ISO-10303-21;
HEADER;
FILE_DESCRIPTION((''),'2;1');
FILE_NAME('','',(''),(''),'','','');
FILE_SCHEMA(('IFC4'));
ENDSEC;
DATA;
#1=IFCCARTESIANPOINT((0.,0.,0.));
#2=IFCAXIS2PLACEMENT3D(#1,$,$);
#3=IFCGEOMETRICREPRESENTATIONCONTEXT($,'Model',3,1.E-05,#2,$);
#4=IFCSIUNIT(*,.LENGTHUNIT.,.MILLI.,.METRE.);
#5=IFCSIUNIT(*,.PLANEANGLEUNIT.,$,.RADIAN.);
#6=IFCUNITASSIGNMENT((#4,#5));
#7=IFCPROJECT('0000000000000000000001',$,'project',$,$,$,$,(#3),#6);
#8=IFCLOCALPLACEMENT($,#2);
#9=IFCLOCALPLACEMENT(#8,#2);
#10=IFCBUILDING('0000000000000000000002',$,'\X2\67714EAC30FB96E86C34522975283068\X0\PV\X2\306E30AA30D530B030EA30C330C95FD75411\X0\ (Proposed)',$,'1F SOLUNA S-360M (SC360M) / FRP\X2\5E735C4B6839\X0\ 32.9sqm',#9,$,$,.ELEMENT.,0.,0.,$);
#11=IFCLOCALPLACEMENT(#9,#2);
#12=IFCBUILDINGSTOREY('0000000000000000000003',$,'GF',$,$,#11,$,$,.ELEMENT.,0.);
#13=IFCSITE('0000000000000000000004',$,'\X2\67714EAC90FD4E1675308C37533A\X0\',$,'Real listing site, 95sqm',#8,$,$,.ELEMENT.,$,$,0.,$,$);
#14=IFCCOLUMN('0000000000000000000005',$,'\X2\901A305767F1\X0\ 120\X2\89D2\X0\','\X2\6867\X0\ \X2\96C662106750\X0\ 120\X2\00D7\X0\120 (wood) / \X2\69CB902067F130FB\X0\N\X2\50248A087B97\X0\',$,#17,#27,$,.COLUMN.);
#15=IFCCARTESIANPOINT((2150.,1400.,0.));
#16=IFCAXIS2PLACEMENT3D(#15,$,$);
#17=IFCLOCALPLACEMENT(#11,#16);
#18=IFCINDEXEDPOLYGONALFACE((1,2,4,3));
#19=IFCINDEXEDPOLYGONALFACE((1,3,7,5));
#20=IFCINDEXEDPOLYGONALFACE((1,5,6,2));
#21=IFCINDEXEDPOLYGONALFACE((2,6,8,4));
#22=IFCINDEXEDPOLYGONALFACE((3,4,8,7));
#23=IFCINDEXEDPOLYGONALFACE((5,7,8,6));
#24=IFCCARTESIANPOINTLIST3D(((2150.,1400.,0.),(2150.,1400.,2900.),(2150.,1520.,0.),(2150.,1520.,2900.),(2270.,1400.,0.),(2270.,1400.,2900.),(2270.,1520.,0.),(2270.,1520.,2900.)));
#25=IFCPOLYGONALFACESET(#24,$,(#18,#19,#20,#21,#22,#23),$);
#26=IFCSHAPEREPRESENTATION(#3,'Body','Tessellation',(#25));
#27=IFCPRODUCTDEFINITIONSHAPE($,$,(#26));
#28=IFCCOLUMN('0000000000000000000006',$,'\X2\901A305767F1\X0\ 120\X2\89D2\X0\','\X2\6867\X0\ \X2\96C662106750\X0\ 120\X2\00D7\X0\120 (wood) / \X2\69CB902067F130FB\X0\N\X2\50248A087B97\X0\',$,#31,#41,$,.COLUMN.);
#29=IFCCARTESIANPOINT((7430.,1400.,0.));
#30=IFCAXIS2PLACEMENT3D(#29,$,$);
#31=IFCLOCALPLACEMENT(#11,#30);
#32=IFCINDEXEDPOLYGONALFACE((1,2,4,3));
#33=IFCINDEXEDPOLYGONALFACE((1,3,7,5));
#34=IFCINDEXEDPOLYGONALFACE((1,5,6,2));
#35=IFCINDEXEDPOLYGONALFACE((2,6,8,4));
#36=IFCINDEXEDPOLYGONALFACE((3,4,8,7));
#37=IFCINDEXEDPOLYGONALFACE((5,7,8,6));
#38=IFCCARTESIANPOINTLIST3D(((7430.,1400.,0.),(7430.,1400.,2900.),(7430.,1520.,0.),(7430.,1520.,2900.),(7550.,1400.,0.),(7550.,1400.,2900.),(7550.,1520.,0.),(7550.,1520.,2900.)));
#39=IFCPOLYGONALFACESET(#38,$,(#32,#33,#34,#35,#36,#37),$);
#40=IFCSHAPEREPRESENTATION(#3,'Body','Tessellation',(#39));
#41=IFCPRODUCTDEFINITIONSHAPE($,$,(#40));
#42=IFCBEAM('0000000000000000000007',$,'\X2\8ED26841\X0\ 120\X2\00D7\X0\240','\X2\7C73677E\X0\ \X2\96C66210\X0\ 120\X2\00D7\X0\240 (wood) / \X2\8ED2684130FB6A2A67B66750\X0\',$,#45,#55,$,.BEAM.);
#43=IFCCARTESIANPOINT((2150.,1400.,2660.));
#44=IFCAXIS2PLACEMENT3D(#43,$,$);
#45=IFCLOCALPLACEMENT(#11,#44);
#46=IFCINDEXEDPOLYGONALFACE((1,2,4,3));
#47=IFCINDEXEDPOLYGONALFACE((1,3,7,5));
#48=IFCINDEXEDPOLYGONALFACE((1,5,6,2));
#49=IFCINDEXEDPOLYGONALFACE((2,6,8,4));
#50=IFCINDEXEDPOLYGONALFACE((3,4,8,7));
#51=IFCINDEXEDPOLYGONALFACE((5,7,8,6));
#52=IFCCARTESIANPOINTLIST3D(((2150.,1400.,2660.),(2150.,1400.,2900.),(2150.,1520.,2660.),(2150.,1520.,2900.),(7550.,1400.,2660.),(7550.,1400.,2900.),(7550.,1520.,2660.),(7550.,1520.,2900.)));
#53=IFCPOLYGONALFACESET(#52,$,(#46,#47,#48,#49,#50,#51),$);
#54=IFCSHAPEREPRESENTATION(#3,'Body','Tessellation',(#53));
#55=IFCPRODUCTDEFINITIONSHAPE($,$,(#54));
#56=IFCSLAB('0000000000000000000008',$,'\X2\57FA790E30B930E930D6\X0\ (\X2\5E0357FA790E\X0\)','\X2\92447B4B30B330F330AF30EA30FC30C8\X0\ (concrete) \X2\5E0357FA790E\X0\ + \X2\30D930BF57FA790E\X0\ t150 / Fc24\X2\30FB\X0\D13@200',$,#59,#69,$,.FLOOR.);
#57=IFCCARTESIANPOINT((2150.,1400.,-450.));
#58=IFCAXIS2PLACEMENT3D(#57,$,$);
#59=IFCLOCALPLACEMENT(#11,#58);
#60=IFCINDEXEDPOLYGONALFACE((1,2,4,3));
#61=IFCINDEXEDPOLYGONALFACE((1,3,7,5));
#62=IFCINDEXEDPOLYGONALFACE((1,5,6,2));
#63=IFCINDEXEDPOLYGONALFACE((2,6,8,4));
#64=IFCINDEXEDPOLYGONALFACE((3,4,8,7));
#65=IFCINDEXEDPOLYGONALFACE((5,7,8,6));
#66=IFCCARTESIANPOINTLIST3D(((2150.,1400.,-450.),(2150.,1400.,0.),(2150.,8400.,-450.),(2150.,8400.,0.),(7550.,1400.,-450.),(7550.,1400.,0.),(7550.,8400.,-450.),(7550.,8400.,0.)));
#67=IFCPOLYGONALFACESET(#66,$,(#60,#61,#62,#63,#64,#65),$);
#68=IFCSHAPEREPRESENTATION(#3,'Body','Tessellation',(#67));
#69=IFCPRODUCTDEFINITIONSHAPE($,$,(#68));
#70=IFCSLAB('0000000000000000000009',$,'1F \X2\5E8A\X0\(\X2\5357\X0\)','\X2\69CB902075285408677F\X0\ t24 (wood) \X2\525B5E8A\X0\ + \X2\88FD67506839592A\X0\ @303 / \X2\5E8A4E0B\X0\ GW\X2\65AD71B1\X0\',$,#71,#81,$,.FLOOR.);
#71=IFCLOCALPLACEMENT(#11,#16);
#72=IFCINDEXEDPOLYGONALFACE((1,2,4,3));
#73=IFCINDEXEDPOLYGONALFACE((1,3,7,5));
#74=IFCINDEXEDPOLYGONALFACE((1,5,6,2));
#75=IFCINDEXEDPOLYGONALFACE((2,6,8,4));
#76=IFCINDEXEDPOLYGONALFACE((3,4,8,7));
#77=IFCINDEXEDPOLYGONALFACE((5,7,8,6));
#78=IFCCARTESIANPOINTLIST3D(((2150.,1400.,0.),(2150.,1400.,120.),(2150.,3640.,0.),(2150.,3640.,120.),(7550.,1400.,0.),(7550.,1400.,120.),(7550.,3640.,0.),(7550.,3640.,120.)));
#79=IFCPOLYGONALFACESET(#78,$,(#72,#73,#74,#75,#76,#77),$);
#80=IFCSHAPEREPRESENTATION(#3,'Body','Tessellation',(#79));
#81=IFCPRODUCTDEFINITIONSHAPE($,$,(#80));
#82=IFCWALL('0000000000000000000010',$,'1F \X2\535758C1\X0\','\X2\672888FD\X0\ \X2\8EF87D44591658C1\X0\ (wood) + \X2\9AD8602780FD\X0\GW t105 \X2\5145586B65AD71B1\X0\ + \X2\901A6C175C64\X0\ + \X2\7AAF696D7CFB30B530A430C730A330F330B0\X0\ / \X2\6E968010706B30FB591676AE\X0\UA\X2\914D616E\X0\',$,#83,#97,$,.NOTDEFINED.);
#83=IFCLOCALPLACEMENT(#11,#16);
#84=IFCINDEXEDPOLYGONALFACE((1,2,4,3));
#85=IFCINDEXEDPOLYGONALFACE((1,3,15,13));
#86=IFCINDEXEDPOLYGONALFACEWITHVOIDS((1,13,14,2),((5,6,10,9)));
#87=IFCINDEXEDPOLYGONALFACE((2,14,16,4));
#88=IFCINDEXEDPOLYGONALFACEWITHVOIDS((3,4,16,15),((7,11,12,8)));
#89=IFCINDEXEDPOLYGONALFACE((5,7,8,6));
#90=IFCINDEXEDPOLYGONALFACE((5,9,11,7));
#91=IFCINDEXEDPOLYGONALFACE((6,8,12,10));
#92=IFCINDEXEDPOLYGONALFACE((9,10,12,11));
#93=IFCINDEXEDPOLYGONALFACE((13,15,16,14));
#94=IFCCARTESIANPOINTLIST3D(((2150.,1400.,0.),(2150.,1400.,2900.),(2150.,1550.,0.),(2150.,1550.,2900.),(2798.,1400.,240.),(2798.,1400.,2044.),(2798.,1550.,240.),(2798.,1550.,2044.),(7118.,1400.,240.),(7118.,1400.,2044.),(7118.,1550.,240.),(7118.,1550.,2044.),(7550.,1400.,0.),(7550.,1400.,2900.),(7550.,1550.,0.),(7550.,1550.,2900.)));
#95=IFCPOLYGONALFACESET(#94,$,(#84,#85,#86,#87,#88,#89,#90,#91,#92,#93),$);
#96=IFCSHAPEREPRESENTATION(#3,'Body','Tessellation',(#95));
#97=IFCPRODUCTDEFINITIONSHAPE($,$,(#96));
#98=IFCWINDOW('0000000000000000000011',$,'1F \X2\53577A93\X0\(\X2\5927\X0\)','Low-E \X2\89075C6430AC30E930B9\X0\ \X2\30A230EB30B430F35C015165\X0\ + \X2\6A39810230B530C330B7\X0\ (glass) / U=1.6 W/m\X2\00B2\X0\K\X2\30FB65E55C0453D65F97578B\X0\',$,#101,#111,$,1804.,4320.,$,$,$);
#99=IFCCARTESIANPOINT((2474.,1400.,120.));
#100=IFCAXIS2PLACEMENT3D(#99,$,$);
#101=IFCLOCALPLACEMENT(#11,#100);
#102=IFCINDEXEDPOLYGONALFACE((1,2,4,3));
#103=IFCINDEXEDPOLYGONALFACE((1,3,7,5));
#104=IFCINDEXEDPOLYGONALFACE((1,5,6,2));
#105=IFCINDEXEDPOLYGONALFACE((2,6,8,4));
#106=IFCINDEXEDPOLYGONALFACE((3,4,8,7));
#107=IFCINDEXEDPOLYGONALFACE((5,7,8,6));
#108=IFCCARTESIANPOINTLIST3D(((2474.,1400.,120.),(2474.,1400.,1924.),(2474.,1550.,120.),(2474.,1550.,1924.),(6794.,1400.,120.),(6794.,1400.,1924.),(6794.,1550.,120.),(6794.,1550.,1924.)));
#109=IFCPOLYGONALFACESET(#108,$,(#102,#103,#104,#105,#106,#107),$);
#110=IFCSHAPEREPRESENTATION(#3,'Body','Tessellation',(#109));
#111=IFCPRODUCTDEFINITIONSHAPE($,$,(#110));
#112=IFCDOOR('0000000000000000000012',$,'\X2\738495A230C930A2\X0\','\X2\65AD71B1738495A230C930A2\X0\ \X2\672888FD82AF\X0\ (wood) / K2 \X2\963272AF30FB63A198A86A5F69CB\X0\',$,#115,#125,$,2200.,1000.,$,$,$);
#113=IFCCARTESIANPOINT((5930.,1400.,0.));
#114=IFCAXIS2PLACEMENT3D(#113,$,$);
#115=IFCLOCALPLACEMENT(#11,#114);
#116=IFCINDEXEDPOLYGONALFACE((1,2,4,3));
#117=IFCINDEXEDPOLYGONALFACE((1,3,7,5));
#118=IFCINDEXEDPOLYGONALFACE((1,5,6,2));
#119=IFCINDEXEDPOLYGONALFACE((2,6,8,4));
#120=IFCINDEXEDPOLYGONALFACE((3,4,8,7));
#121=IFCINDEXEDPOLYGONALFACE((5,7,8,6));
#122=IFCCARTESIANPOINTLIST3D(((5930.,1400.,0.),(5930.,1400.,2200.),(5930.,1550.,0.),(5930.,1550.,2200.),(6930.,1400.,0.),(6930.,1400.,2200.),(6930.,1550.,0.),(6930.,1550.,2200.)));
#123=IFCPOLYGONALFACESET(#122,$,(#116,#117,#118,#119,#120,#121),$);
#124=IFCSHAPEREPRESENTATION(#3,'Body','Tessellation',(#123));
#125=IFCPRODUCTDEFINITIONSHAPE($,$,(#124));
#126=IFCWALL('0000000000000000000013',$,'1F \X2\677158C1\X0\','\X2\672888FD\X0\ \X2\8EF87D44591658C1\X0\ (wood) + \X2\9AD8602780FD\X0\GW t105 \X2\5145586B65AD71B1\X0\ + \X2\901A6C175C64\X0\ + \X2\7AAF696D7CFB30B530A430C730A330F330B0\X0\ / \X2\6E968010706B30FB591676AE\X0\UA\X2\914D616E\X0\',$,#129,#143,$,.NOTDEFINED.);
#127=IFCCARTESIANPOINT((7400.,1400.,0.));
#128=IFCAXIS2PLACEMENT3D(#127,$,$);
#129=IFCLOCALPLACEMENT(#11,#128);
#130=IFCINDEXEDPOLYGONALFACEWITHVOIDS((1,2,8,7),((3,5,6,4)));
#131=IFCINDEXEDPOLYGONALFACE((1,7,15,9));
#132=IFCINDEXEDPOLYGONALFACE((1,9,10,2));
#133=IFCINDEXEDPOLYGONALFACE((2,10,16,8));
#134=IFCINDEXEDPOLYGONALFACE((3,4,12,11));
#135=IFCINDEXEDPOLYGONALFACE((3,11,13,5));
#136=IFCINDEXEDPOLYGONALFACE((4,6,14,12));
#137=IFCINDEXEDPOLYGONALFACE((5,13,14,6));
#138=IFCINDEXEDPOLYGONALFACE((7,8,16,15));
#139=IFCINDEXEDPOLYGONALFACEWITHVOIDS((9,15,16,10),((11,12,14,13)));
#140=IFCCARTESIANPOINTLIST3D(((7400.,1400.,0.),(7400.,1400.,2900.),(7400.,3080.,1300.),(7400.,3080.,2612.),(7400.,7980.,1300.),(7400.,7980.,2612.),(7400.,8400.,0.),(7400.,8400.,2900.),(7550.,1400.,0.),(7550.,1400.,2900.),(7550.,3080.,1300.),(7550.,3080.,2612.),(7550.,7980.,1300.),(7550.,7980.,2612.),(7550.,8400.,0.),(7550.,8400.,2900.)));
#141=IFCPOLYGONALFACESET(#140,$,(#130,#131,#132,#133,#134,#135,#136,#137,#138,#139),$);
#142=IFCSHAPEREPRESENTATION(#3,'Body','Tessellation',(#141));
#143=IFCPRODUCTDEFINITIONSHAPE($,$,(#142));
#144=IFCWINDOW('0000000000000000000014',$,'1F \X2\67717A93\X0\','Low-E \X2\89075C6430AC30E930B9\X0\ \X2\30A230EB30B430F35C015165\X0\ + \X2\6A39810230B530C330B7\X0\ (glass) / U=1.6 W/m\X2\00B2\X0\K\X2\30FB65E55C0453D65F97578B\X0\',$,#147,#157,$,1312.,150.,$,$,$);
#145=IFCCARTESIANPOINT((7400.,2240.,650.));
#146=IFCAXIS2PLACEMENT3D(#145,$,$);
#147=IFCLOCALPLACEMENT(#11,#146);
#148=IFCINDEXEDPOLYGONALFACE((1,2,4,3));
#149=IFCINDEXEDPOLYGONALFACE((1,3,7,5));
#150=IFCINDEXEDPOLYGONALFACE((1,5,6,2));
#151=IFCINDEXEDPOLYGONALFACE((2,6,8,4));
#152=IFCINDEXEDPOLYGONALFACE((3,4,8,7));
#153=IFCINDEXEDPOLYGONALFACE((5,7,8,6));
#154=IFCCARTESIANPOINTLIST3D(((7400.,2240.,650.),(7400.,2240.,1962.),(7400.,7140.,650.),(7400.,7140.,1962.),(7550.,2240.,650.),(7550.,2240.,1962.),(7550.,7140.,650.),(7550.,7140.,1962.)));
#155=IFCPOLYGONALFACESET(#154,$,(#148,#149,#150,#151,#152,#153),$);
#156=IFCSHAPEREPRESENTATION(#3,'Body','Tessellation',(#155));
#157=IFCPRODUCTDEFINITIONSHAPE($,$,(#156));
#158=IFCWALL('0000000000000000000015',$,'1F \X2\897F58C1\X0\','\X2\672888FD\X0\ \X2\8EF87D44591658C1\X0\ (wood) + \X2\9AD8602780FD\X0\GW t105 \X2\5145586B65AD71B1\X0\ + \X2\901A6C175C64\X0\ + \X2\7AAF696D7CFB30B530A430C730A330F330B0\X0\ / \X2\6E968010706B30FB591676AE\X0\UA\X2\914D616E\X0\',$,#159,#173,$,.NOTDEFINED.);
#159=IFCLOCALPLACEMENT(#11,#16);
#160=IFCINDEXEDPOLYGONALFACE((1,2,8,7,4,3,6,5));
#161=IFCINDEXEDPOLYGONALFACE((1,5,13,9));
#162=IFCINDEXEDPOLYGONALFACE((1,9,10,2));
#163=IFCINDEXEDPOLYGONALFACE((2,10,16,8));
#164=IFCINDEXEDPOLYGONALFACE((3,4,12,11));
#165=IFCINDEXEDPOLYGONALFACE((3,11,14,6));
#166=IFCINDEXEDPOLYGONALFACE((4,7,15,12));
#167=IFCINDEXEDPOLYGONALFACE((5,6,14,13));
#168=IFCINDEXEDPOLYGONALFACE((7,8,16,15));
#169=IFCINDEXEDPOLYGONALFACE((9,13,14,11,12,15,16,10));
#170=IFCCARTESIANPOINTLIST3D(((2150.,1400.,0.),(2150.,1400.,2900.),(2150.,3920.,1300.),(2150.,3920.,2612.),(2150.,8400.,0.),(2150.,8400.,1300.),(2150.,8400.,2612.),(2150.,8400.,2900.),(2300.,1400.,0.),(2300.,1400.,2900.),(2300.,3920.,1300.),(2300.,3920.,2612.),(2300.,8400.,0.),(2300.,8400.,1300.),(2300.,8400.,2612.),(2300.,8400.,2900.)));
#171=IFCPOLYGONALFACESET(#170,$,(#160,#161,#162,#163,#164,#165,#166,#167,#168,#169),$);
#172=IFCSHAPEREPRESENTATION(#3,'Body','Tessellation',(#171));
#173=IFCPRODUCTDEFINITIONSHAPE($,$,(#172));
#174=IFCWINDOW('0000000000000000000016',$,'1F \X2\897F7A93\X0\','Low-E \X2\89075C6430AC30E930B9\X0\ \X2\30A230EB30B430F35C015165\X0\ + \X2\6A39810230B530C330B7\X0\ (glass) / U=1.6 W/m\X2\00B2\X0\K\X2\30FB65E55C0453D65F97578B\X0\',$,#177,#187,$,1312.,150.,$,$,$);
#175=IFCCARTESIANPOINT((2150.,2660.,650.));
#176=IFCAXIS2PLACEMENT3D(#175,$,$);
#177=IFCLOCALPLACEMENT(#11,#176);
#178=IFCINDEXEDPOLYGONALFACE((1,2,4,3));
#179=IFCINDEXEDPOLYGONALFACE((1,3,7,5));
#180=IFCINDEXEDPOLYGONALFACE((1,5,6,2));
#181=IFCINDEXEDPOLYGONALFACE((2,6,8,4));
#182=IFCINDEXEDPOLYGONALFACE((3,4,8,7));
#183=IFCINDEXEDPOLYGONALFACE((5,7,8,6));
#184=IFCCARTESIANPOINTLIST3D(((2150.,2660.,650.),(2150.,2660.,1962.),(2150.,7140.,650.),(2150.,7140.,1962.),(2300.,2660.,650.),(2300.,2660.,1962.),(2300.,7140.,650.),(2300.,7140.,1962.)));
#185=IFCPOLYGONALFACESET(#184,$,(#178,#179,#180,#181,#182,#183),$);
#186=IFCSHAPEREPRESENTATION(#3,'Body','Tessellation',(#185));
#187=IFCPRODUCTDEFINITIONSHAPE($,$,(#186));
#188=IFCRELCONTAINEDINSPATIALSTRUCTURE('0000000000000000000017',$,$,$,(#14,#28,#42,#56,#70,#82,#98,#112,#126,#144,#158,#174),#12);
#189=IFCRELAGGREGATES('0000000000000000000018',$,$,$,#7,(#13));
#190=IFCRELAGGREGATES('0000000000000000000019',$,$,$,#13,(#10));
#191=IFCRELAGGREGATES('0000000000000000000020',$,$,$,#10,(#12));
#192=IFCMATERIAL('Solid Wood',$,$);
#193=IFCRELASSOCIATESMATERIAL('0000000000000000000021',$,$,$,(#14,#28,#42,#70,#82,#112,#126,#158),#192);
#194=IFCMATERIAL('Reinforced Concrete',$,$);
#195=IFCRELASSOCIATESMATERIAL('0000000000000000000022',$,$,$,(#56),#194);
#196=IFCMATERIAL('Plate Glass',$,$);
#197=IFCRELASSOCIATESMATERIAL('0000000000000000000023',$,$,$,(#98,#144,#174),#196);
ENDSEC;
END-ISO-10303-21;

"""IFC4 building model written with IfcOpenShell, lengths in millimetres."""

from ifc_helpers import new_model, si_unit, frame, frame_2d, origin, place, context, project, spatial, rectangle, extrude, material, element, fill, save


model = new_model("IFC4")

# Units and contexts
model_context = context("Model", 3, precision=1e-05, world=origin())
ifc_project = project(units=[si_unit("LENGTHUNIT", "METRE", prefix="MILLI"), si_unit("PLANEANGLEUNIT", "RADIAN")], contexts=[model_context])

# Site, building, storey
site_placement = place(None, origin())
site = spatial("IfcSite", under=ifc_project, at=site_placement, Name="東京都世田谷区", ObjectType="Real listing site, 95sqm", CompositionType="ELEMENT", RefElevation=0.0)
building_placement = place(site_placement, origin())
building = spatial("IfcBuilding", under=site, at=building_placement, Name="東京・雨水利用とPVのオフグリッド志向 (Proposed)", ObjectType="1F SOLUNA S-360M (SC360M) / FRP平屋根 32.9sqm", CompositionType="ELEMENT", ElevationOfRefHeight=0.0, ElevationOfTerrain=0.0)
storey_placement = place(building_placement, origin())
storey = spatial("IfcBuildingStorey", under=building, at=storey_placement, Name="GF", CompositionType="ELEMENT", Elevation=0.0)

# Columns
ifc_material_1 = material(Name="Solid Wood")
column_1_placement = place(storey_placement, frame((2150.0, 1400.0, 0.0)))
element("IfcColumn", 1, at=column_1_placement, inside=storey, material=ifc_material_1, Name="通し柱 120角", Description="桧 集成材 120×120 (wood) / 構造柱・N値計算", PredefinedType="COLUMN", context=model_context, shape_type="SweptSolid", body=[
    extrude(rectangle(XDim=120.0, YDim=120.0, at=frame_2d((60.0, 60.0))), frame((2150.0, 1400.0, 0.0)), (0.0, 0.0, 1.0), 2900.0),
])
column_2_placement = place(storey_placement, frame((7430.0, 1400.0, 0.0)))
element("IfcColumn", 2, at=column_2_placement, inside=storey, material=ifc_material_1, Name="通し柱 120角", Description="桧 集成材 120×120 (wood) / 構造柱・N値計算", PredefinedType="COLUMN", context=model_context, shape_type="SweptSolid", body=[
    extrude(rectangle(XDim=120.0, YDim=120.0, at=frame_2d((60.0, 60.0))), frame((7430.0, 1400.0, 0.0)), (0.0, 0.0, 1.0), 2900.0),
])

# Beam
beam_1_placement = place(storey_placement, frame((2150.0, 1400.0, 2660.0)))
element("IfcBeam", 3, at=beam_1_placement, inside=storey, material=ifc_material_1, Name="軒桁 120×240", Description="米松 集成 120×240 (wood) / 軒桁・横架材", PredefinedType="BEAM", context=model_context, shape_type="SweptSolid", body=[
    extrude(rectangle(XDim=5400.0, YDim=120.0, at=frame_2d((2700.0, 60.0))), frame((2150.0, 1400.0, 2660.0)), (0.0, 0.0, 1.0), 240.0),
])

# Slabs
ifc_material_2 = material(Name="Reinforced Concrete")
slab_1_placement = place(storey_placement, frame((2150.0, 1400.0, -450.0)))
element("IfcSlab", 4, at=slab_1_placement, inside=storey, material=ifc_material_2, Name="基礎スラブ (布基礎)", Description="鉄筋コンクリート (concrete) 布基礎 + ベタ基礎 t150 / Fc24・D13@200", PredefinedType="FLOOR", context=model_context, shape_type="SweptSolid", body=[
    extrude(rectangle(XDim=5400.0, YDim=7000.0, at=frame_2d((2700.0, 3500.0))), frame((2150.0, 1400.0, -450.0)), (0.0, 0.0, 1.0), 450.0),
])
slab_2_placement = place(storey_placement, frame((2150.0, 1400.0, 0.0)))
element("IfcSlab", 5, at=slab_2_placement, inside=storey, material=ifc_material_1, Name="1F 床(南)", Description="構造用合板 t24 (wood) 剛床 + 製材根太 @303 / 床下 GW断熱", PredefinedType="FLOOR", context=model_context, shape_type="SweptSolid", body=[
    extrude(rectangle(XDim=5400.0, YDim=2240.0, at=frame_2d((2700.0, 1120.0))), frame((2150.0, 1400.0, 0.0)), (0.0, 0.0, 1.0), 120.0),
])

# Wall, openings, window, door
wall_1_placement = place(storey_placement, frame((2150.0, 1400.0, 0.0)))
wall_1 = element("IfcWall", 6, at=wall_1_placement, inside=storey, material=ifc_material_1, Name="1F 南壁", Description="木製 軸組外壁 (wood) + 高性能GW t105 充填断熱 + 通気層 + 窯業系サイディング / 準耐火・外皮UA配慮", PredefinedType="NOTDEFINED", context=model_context, shape_type="SweptSolid", body=[
    extrude(rectangle(XDim=5400.0, YDim=150.0, at=frame_2d((2700.0, 75.0))), frame((2150.0, 1400.0, 0.0)), (0.0, 0.0, 1.0), 2900.0),
])
opening_1_placement = place(storey_placement, frame((2474.0, 1400.0, 120.0)))
opening_1 = element("IfcOpeningElement", 7, at=opening_1_placement, cuts=wall_1, PredefinedType="NOTDEFINED", context=model_context, shape_type="SweptSolid", body=[
    extrude(rectangle(XDim=4320.0, YDim=150.0, at=frame_2d((2160.0, 75.0))), frame((2474.0, 1400.0, 120.0)), (0.0, 0.0, 1.0), 1804.0),
])
opening_2_placement = place(storey_placement, frame((5930.0, 1400.0, 0.0)))
opening_2 = element("IfcOpeningElement", 8, at=opening_2_placement, cuts=wall_1, PredefinedType="NOTDEFINED", context=model_context, shape_type="SweptSolid", body=[
    extrude(rectangle(XDim=1000.0, YDim=150.0, at=frame_2d((500.0, 75.0))), frame((5930.0, 1400.0, 0.0)), (0.0, 0.0, 1.0), 2200.0),
])
ifc_material_3 = material(Name="Plate Glass")
window_1_placement = place(storey_placement, frame((2474.0, 1400.0, 120.0)))
window_1 = element("IfcWindow", 9, at=window_1_placement, inside=storey, material=ifc_material_3, Name="1F 南窓(大)", Description="Low-E 複層ガラス アルゴン封入 + 樹脂サッシ (glass) / U=1.6 W/m²K・日射取得型", OverallHeight=1804.0, OverallWidth=4320.0, context=model_context, shape_type="SweptSolid", body=[
    extrude(rectangle(XDim=4320.0, YDim=150.0, at=frame_2d((2160.0, 75.0))), frame((2474.0, 1400.0, 120.0)), (0.0, 0.0, 1.0), 1804.0),
])
fill(opening_1, window_1)
door_placement = place(storey_placement, frame((5930.0, 1400.0, 0.0)))
door = element("IfcDoor", 10, at=door_placement, inside=storey, material=ifc_material_1, Name="玄関ドア", Description="断熱玄関ドア 木製芯 (wood) / K2 防犯・採風機構", OverallHeight=2200.0, OverallWidth=1000.0, context=model_context, shape_type="SweptSolid", body=[
    extrude(rectangle(XDim=1000.0, YDim=150.0, at=frame_2d((500.0, 75.0))), frame((5930.0, 1400.0, 0.0)), (0.0, 0.0, 1.0), 2200.0),
])
fill(opening_2, door)

# Walls, openings, windows
wall_2_placement = place(storey_placement, frame((7400.0, 1400.0, 0.0)))
wall_2 = element("IfcWall", 11, at=wall_2_placement, inside=storey, material=ifc_material_1, Name="1F 東壁", Description="木製 軸組外壁 (wood) + 高性能GW t105 充填断熱 + 通気層 + 窯業系サイディング / 準耐火・外皮UA配慮", PredefinedType="NOTDEFINED", context=model_context, shape_type="SweptSolid", body=[
    extrude(rectangle(XDim=150.0, YDim=7000.0, at=frame_2d((75.0, 3500.0))), frame((7400.0, 1400.0, 0.0)), (0.0, 0.0, 1.0), 2900.0),
])
opening_3_placement = place(storey_placement, frame((7400.0, 2240.0, 650.0)))
opening_3 = element("IfcOpeningElement", 12, at=opening_3_placement, cuts=wall_2, PredefinedType="NOTDEFINED", context=model_context, shape_type="SweptSolid", body=[
    extrude(rectangle(XDim=150.0, YDim=4900.0, at=frame_2d((75.0, 2450.0))), frame((7400.0, 2240.0, 650.0)), (0.0, 0.0, 1.0), 1312.0),
])
window_2_placement = place(storey_placement, frame((7400.0, 2240.0, 650.0)))
window_2 = element("IfcWindow", 13, at=window_2_placement, inside=storey, material=ifc_material_3, Name="1F 東窓", Description="Low-E 複層ガラス アルゴン封入 + 樹脂サッシ (glass) / U=1.6 W/m²K・日射取得型", OverallHeight=1312.0, OverallWidth=150.0, context=model_context, shape_type="SweptSolid", body=[
    extrude(rectangle(XDim=150.0, YDim=4900.0, at=frame_2d((75.0, 2450.0))), frame((7400.0, 2240.0, 650.0)), (0.0, 0.0, 1.0), 1312.0),
])
fill(opening_3, window_2)
wall_3_placement = place(storey_placement, frame((2150.0, 1400.0, 0.0)))
wall_3 = element("IfcWall", 14, at=wall_3_placement, inside=storey, material=ifc_material_1, Name="1F 西壁", Description="木製 軸組外壁 (wood) + 高性能GW t105 充填断熱 + 通気層 + 窯業系サイディング / 準耐火・外皮UA配慮", PredefinedType="NOTDEFINED", context=model_context, shape_type="SweptSolid", body=[
    extrude(rectangle(XDim=150.0, YDim=7000.0, at=frame_2d((75.0, 3500.0))), frame((2150.0, 1400.0, 0.0)), (0.0, 0.0, 1.0), 2900.0),
])
opening_4_placement = place(storey_placement, frame((2150.0, 2660.0, 650.0)))
opening_4 = element("IfcOpeningElement", 15, at=opening_4_placement, cuts=wall_3, PredefinedType="NOTDEFINED", context=model_context, shape_type="SweptSolid", body=[
    extrude(rectangle(XDim=150.0, YDim=4480.0, at=frame_2d((75.0, 2240.0))), frame((2150.0, 2660.0, 650.0)), (0.0, 0.0, 1.0), 1312.0),
])
window_3_placement = place(storey_placement, frame((2150.0, 2660.0, 650.0)))
window_3 = element("IfcWindow", 16, at=window_3_placement, inside=storey, material=ifc_material_3, Name="1F 西窓", Description="Low-E 複層ガラス アルゴン封入 + 樹脂サッシ (glass) / U=1.6 W/m²K・日射取得型", OverallHeight=1312.0, OverallWidth=150.0, context=model_context, shape_type="SweptSolid", body=[
    extrude(rectangle(XDim=150.0, YDim=4480.0, at=frame_2d((75.0, 2240.0))), frame((2150.0, 2660.0, 650.0)), (0.0, 0.0, 1.0), 1312.0),
])
fill(opening_4, window_3)

save(model, "model.ifc")
